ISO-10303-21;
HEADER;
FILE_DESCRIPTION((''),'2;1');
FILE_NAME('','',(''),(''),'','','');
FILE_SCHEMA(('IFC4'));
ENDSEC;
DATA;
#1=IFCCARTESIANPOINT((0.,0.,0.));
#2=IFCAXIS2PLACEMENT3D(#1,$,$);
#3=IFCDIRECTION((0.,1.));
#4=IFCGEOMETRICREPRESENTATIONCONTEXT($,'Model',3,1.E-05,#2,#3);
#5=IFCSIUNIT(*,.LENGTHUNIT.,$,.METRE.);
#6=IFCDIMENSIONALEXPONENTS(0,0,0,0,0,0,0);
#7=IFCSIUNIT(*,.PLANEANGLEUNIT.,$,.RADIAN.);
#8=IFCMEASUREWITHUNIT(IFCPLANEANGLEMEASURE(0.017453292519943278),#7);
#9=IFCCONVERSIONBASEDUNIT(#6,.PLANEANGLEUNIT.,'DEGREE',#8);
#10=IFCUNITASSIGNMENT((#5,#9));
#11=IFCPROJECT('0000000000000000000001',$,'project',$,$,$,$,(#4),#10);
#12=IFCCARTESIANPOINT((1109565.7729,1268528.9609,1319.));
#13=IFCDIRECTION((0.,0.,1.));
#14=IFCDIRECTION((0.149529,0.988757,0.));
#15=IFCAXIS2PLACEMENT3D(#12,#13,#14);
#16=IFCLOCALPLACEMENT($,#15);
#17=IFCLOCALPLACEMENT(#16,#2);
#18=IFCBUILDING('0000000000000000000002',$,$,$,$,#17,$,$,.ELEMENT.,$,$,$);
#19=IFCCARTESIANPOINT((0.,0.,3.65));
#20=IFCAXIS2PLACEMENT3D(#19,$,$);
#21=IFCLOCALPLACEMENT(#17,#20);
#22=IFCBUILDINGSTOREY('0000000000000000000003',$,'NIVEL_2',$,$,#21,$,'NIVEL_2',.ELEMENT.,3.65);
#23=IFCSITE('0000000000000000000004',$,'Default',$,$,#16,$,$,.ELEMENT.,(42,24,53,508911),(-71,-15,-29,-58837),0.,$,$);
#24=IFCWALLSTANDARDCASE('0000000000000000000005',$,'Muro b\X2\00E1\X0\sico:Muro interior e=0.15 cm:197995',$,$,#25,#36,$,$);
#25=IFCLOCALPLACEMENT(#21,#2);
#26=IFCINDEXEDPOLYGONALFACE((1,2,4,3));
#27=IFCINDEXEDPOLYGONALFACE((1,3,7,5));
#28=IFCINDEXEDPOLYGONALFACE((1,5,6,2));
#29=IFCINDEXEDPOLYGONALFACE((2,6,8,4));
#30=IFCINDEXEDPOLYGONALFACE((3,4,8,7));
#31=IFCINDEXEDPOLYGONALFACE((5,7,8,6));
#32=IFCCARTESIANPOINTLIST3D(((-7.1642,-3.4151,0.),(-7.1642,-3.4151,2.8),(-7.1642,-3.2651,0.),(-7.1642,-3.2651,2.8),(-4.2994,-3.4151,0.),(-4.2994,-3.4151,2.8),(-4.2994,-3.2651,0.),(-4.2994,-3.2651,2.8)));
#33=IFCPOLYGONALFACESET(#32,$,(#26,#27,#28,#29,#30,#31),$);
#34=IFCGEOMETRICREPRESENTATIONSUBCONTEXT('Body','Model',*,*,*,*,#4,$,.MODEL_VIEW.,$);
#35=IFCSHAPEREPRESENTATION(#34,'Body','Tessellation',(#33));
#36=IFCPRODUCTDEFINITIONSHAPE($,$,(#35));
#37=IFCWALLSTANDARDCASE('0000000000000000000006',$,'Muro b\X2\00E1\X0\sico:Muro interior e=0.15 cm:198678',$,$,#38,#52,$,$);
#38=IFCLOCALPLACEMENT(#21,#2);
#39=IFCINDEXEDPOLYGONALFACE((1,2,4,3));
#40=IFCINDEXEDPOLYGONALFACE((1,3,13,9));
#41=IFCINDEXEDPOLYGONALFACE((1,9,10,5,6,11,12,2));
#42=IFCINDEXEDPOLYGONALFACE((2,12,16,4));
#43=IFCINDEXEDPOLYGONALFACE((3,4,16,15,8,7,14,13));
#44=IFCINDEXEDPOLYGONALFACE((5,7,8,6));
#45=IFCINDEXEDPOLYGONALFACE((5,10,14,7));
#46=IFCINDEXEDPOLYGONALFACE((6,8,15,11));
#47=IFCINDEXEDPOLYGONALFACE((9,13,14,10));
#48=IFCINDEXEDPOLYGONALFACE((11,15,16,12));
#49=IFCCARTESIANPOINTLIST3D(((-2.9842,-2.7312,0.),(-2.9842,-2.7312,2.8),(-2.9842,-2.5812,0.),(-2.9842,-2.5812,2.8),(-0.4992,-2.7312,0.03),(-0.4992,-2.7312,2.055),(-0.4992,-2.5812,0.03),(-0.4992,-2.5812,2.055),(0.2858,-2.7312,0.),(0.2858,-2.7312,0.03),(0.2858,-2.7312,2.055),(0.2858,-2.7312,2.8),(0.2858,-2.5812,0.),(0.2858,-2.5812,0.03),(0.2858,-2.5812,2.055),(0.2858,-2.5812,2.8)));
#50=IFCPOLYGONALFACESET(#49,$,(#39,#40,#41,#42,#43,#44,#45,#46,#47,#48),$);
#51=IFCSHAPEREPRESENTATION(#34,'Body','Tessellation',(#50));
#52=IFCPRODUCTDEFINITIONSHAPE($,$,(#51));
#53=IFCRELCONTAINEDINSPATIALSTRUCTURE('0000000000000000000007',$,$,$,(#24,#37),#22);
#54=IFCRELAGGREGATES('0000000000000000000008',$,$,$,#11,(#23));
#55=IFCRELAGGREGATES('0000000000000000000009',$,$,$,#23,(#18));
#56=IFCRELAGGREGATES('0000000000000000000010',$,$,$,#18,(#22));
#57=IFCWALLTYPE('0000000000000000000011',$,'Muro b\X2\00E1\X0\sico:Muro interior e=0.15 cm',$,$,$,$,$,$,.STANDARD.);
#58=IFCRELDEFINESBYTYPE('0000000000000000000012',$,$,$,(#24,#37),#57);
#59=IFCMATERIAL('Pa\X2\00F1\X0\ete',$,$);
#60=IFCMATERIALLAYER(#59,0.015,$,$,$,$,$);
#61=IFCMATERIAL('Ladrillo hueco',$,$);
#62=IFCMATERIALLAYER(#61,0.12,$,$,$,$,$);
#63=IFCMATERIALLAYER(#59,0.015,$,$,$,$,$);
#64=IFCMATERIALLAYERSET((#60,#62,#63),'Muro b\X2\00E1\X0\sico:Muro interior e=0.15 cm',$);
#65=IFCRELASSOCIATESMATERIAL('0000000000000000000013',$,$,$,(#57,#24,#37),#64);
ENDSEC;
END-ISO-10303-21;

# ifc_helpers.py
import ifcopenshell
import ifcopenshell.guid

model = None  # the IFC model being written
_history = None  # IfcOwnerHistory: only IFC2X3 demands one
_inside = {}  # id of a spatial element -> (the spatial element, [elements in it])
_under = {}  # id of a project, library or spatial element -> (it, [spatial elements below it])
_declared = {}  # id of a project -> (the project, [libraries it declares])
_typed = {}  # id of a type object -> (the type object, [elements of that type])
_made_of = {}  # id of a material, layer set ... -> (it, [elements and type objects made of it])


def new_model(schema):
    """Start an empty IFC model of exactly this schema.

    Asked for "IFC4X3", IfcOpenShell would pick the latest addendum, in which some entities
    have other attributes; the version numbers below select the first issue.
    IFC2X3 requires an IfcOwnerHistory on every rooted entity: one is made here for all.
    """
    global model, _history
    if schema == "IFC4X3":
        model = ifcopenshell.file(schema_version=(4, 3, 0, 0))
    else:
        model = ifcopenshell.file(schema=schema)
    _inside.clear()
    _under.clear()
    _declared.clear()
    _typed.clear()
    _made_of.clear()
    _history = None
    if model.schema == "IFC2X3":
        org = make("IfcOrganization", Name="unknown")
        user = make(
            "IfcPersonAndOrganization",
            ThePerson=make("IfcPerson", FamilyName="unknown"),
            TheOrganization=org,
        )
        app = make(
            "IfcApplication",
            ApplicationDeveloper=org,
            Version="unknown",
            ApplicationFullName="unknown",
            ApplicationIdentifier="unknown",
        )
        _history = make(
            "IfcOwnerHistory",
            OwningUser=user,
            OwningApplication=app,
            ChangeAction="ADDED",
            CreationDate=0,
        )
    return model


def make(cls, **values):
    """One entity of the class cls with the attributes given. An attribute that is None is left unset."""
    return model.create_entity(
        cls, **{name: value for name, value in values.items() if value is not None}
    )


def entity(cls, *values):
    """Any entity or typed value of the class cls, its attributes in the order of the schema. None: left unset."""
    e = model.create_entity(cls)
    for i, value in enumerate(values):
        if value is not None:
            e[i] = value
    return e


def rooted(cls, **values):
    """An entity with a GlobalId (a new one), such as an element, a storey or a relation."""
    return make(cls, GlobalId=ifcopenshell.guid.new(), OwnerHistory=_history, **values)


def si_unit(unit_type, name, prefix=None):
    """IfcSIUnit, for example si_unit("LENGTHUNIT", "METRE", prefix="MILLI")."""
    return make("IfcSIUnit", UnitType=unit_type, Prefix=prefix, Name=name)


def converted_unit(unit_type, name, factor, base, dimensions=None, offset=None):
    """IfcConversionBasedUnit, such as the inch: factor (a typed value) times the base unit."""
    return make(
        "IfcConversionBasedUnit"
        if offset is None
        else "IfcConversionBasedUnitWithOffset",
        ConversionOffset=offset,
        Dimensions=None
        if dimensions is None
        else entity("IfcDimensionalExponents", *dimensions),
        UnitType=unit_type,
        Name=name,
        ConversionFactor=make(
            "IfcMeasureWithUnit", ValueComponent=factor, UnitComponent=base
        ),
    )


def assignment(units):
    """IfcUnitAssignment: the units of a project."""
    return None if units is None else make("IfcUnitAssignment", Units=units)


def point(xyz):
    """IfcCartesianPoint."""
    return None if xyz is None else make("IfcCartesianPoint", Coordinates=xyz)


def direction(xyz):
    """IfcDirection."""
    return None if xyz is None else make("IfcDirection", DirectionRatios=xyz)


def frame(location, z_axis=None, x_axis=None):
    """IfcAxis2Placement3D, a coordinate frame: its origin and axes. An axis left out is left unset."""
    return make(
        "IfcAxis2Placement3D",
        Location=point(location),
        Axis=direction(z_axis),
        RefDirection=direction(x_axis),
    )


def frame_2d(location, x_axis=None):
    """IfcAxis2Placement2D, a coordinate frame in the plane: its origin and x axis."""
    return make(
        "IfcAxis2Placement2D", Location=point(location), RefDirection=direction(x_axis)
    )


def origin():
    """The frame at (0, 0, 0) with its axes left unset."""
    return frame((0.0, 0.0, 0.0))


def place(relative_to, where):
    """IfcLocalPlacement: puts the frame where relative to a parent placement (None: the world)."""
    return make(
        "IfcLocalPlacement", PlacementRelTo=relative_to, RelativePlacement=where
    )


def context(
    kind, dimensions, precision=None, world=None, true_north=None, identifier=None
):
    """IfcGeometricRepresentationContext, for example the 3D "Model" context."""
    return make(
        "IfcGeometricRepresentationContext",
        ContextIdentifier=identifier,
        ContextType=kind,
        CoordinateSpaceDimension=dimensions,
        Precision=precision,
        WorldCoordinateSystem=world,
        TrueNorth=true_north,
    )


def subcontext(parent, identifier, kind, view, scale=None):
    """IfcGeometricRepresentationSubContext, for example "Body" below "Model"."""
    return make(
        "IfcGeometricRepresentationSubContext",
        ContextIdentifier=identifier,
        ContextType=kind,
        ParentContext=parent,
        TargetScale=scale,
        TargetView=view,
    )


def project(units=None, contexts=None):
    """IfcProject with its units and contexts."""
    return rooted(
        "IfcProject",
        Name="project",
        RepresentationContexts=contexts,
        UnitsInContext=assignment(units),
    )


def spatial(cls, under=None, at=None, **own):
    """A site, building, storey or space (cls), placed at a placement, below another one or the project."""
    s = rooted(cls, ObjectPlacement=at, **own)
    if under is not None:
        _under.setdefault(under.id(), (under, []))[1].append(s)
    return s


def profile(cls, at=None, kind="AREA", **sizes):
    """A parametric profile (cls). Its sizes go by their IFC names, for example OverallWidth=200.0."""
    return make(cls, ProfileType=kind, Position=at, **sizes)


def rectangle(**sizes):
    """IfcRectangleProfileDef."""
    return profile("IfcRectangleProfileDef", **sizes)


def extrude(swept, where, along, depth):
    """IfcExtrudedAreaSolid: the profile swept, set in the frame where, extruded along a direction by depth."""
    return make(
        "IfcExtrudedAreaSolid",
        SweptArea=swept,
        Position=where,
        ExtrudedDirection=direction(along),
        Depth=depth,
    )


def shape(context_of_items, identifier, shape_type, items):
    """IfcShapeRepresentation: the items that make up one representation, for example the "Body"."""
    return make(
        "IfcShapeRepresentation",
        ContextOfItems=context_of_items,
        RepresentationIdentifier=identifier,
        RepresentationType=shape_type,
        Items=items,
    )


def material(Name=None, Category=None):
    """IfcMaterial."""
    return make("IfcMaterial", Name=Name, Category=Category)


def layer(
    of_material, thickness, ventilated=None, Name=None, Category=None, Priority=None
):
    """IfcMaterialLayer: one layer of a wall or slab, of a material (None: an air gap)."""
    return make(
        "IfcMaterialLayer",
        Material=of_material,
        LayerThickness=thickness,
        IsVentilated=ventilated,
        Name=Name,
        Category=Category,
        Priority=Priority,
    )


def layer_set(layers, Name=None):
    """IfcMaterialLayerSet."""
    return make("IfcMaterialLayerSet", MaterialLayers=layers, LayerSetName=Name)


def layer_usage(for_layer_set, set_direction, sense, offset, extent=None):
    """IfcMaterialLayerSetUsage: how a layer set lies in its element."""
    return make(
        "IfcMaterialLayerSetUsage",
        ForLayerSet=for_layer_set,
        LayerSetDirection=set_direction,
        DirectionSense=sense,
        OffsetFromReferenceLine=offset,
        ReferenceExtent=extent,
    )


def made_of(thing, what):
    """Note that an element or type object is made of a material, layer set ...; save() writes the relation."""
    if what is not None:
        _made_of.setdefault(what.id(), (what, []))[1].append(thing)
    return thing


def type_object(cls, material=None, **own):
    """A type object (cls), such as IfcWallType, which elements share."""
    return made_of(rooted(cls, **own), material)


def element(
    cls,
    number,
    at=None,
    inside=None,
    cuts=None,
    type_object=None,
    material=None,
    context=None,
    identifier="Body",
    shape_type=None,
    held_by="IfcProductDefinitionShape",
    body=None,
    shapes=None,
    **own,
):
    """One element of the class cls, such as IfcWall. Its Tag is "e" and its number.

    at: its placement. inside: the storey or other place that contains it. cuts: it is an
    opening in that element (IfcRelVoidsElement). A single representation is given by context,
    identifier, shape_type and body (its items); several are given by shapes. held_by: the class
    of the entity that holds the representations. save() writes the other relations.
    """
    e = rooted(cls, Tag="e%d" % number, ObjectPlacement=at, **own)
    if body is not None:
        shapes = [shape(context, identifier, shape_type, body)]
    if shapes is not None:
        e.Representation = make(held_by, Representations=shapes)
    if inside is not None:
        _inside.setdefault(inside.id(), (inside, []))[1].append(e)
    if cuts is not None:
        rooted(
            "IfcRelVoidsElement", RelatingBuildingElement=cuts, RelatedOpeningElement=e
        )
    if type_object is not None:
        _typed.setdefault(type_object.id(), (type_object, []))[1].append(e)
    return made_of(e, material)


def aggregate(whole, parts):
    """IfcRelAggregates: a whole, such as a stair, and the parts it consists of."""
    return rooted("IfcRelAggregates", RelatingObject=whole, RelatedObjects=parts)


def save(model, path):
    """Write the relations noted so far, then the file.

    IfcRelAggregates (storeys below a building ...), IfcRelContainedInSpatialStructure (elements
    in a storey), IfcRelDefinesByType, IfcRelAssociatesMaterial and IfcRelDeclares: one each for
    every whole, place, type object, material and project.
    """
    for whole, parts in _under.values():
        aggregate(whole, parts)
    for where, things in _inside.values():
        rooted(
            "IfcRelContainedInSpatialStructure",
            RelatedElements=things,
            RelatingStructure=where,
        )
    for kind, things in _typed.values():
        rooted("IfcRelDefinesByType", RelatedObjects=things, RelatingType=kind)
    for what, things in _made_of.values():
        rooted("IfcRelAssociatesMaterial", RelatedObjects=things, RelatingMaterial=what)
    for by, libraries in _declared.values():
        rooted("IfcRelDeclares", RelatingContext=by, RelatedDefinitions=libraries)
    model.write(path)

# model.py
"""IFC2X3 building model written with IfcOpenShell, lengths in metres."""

from ifc_helpers import new_model, entity, si_unit, converted_unit, direction, frame, frame_2d, origin, place, context, subcontext, project, spatial, rectangle, extrude, material, layer, layer_set, layer_usage, type_object, element, save


model = new_model("IFC2X3")

# Units and contexts
model_context = context("Model", 3, precision=1e-05, world=origin(), true_north=direction((0.0, 1.0)))
body_context = subcontext(model_context, "Body", "Model", "MODEL_VIEW")
ifc_project = project(units=[si_unit("LENGTHUNIT", "METRE"), converted_unit("PLANEANGLEUNIT", "DEGREE", entity("IfcPlaneAngleMeasure", 0.017453292519943278), si_unit("PLANEANGLEUNIT", "RADIAN"), dimensions=[0, 0, 0, 0, 0, 0, 0])], contexts=[model_context])

# Site, building, storey
site_placement = place(None, frame((1109565.7729, 1268528.9609, 1319.0), z_axis=(0.0, 0.0, 1.0), x_axis=(0.149529, 0.988757, 0.0)))
site = spatial("IfcSite", under=ifc_project, at=site_placement, Name="Default", CompositionType="ELEMENT", RefLatitude=(42, 24, 53, 508911), RefLongitude=(-71, -15, -29, -58837), RefElevation=0.0)
building_placement = place(site_placement, origin())
building = spatial("IfcBuilding", under=site, at=building_placement, CompositionType="ELEMENT")
storey_placement = place(building_placement, frame((0.0, 0.0, 3.65)))
storey = spatial("IfcBuildingStorey", under=building, at=storey_placement, Name="NIVEL_2", LongName="NIVEL_2", CompositionType="ELEMENT", Elevation=3.65)

# Wall
ifc_material_1 = material(Name="Pañete")
ifc_layer_1 = layer(ifc_material_1, 0.015)
ifc_material_2 = material(Name="Ladrillo hueco")
ifc_layer_2 = layer(ifc_material_2, 0.12)
ifc_layer_3 = layer(ifc_material_1, 0.015)
ifc_layer_set_1 = layer_set([ifc_layer_1, ifc_layer_2, ifc_layer_3], Name="Muro básico:Muro interior e=0.15 cm")
ifc_layer_usage_1 = layer_usage(ifc_layer_set_1, "AXIS2", "NEGATIVE", 0.075)
wall_type_1 = type_object("IfcWallType", Name="Muro básico:Muro interior e=0.15 cm", PredefinedType="STANDARD", material=ifc_layer_set_1)
wall_1_placement = place(storey_placement, frame((-4.2994, -3.3401, 0.0), z_axis=(0.0, 0.0, 1.0), x_axis=(-1.0, 0.0, 0.0)))
element("IfcWallStandardCase", 1, at=wall_1_placement, inside=storey, type_object=wall_type_1, material=ifc_layer_usage_1, Name="Muro básico:Muro interior e=0.15 cm:197995", context=body_context, shape_type="SweptSolid", body=[
    extrude(rectangle(XDim=2.8649, YDim=0.15, at=frame_2d((1.4324, 0.0), x_axis=(-1.0, 0.0))), origin(), (0.0, 0.0, 1.0), 2.8),
])

# Wall, opening
ifc_layer_usage_2 = layer_usage(ifc_layer_set_1, "AXIS2", "NEGATIVE", 0.075)
wall_2_placement = place(storey_placement, frame((-2.9842, -2.6562, 0.0)))
wall_2 = element("IfcWallStandardCase", 2, at=wall_2_placement, inside=storey, type_object=wall_type_1, material=ifc_layer_usage_2, Name="Muro básico:Muro interior e=0.15 cm:198678", context=body_context, shape_type="SweptSolid", body=[
    extrude(rectangle(XDim=3.27, YDim=0.15, at=frame_2d((1.635, 0.0), x_axis=(-1.0, 0.0))), origin(), (0.0, 0.0, 1.0), 2.8),
])
opening_1_placement = place(wall_2_placement, frame((3.285, 0.075, 0.03)))
element("IfcOpeningElement", 3, at=opening_1_placement, cuts=wall_2, ObjectType="Opening", context=body_context, shape_type="SweptSolid", body=[
    extrude(rectangle(XDim=2.025, YDim=0.8, at=frame_2d((1.0125, 0.4), x_axis=(1.0, 0.0))), frame((0.0, 0.0, 0.0), z_axis=(0.0, -1.0, 0.0), x_axis=(0.0, 0.0, 1.0)), (0.0, 0.0, 1.0), 0.15),
])

save(model, "model.ifc")
